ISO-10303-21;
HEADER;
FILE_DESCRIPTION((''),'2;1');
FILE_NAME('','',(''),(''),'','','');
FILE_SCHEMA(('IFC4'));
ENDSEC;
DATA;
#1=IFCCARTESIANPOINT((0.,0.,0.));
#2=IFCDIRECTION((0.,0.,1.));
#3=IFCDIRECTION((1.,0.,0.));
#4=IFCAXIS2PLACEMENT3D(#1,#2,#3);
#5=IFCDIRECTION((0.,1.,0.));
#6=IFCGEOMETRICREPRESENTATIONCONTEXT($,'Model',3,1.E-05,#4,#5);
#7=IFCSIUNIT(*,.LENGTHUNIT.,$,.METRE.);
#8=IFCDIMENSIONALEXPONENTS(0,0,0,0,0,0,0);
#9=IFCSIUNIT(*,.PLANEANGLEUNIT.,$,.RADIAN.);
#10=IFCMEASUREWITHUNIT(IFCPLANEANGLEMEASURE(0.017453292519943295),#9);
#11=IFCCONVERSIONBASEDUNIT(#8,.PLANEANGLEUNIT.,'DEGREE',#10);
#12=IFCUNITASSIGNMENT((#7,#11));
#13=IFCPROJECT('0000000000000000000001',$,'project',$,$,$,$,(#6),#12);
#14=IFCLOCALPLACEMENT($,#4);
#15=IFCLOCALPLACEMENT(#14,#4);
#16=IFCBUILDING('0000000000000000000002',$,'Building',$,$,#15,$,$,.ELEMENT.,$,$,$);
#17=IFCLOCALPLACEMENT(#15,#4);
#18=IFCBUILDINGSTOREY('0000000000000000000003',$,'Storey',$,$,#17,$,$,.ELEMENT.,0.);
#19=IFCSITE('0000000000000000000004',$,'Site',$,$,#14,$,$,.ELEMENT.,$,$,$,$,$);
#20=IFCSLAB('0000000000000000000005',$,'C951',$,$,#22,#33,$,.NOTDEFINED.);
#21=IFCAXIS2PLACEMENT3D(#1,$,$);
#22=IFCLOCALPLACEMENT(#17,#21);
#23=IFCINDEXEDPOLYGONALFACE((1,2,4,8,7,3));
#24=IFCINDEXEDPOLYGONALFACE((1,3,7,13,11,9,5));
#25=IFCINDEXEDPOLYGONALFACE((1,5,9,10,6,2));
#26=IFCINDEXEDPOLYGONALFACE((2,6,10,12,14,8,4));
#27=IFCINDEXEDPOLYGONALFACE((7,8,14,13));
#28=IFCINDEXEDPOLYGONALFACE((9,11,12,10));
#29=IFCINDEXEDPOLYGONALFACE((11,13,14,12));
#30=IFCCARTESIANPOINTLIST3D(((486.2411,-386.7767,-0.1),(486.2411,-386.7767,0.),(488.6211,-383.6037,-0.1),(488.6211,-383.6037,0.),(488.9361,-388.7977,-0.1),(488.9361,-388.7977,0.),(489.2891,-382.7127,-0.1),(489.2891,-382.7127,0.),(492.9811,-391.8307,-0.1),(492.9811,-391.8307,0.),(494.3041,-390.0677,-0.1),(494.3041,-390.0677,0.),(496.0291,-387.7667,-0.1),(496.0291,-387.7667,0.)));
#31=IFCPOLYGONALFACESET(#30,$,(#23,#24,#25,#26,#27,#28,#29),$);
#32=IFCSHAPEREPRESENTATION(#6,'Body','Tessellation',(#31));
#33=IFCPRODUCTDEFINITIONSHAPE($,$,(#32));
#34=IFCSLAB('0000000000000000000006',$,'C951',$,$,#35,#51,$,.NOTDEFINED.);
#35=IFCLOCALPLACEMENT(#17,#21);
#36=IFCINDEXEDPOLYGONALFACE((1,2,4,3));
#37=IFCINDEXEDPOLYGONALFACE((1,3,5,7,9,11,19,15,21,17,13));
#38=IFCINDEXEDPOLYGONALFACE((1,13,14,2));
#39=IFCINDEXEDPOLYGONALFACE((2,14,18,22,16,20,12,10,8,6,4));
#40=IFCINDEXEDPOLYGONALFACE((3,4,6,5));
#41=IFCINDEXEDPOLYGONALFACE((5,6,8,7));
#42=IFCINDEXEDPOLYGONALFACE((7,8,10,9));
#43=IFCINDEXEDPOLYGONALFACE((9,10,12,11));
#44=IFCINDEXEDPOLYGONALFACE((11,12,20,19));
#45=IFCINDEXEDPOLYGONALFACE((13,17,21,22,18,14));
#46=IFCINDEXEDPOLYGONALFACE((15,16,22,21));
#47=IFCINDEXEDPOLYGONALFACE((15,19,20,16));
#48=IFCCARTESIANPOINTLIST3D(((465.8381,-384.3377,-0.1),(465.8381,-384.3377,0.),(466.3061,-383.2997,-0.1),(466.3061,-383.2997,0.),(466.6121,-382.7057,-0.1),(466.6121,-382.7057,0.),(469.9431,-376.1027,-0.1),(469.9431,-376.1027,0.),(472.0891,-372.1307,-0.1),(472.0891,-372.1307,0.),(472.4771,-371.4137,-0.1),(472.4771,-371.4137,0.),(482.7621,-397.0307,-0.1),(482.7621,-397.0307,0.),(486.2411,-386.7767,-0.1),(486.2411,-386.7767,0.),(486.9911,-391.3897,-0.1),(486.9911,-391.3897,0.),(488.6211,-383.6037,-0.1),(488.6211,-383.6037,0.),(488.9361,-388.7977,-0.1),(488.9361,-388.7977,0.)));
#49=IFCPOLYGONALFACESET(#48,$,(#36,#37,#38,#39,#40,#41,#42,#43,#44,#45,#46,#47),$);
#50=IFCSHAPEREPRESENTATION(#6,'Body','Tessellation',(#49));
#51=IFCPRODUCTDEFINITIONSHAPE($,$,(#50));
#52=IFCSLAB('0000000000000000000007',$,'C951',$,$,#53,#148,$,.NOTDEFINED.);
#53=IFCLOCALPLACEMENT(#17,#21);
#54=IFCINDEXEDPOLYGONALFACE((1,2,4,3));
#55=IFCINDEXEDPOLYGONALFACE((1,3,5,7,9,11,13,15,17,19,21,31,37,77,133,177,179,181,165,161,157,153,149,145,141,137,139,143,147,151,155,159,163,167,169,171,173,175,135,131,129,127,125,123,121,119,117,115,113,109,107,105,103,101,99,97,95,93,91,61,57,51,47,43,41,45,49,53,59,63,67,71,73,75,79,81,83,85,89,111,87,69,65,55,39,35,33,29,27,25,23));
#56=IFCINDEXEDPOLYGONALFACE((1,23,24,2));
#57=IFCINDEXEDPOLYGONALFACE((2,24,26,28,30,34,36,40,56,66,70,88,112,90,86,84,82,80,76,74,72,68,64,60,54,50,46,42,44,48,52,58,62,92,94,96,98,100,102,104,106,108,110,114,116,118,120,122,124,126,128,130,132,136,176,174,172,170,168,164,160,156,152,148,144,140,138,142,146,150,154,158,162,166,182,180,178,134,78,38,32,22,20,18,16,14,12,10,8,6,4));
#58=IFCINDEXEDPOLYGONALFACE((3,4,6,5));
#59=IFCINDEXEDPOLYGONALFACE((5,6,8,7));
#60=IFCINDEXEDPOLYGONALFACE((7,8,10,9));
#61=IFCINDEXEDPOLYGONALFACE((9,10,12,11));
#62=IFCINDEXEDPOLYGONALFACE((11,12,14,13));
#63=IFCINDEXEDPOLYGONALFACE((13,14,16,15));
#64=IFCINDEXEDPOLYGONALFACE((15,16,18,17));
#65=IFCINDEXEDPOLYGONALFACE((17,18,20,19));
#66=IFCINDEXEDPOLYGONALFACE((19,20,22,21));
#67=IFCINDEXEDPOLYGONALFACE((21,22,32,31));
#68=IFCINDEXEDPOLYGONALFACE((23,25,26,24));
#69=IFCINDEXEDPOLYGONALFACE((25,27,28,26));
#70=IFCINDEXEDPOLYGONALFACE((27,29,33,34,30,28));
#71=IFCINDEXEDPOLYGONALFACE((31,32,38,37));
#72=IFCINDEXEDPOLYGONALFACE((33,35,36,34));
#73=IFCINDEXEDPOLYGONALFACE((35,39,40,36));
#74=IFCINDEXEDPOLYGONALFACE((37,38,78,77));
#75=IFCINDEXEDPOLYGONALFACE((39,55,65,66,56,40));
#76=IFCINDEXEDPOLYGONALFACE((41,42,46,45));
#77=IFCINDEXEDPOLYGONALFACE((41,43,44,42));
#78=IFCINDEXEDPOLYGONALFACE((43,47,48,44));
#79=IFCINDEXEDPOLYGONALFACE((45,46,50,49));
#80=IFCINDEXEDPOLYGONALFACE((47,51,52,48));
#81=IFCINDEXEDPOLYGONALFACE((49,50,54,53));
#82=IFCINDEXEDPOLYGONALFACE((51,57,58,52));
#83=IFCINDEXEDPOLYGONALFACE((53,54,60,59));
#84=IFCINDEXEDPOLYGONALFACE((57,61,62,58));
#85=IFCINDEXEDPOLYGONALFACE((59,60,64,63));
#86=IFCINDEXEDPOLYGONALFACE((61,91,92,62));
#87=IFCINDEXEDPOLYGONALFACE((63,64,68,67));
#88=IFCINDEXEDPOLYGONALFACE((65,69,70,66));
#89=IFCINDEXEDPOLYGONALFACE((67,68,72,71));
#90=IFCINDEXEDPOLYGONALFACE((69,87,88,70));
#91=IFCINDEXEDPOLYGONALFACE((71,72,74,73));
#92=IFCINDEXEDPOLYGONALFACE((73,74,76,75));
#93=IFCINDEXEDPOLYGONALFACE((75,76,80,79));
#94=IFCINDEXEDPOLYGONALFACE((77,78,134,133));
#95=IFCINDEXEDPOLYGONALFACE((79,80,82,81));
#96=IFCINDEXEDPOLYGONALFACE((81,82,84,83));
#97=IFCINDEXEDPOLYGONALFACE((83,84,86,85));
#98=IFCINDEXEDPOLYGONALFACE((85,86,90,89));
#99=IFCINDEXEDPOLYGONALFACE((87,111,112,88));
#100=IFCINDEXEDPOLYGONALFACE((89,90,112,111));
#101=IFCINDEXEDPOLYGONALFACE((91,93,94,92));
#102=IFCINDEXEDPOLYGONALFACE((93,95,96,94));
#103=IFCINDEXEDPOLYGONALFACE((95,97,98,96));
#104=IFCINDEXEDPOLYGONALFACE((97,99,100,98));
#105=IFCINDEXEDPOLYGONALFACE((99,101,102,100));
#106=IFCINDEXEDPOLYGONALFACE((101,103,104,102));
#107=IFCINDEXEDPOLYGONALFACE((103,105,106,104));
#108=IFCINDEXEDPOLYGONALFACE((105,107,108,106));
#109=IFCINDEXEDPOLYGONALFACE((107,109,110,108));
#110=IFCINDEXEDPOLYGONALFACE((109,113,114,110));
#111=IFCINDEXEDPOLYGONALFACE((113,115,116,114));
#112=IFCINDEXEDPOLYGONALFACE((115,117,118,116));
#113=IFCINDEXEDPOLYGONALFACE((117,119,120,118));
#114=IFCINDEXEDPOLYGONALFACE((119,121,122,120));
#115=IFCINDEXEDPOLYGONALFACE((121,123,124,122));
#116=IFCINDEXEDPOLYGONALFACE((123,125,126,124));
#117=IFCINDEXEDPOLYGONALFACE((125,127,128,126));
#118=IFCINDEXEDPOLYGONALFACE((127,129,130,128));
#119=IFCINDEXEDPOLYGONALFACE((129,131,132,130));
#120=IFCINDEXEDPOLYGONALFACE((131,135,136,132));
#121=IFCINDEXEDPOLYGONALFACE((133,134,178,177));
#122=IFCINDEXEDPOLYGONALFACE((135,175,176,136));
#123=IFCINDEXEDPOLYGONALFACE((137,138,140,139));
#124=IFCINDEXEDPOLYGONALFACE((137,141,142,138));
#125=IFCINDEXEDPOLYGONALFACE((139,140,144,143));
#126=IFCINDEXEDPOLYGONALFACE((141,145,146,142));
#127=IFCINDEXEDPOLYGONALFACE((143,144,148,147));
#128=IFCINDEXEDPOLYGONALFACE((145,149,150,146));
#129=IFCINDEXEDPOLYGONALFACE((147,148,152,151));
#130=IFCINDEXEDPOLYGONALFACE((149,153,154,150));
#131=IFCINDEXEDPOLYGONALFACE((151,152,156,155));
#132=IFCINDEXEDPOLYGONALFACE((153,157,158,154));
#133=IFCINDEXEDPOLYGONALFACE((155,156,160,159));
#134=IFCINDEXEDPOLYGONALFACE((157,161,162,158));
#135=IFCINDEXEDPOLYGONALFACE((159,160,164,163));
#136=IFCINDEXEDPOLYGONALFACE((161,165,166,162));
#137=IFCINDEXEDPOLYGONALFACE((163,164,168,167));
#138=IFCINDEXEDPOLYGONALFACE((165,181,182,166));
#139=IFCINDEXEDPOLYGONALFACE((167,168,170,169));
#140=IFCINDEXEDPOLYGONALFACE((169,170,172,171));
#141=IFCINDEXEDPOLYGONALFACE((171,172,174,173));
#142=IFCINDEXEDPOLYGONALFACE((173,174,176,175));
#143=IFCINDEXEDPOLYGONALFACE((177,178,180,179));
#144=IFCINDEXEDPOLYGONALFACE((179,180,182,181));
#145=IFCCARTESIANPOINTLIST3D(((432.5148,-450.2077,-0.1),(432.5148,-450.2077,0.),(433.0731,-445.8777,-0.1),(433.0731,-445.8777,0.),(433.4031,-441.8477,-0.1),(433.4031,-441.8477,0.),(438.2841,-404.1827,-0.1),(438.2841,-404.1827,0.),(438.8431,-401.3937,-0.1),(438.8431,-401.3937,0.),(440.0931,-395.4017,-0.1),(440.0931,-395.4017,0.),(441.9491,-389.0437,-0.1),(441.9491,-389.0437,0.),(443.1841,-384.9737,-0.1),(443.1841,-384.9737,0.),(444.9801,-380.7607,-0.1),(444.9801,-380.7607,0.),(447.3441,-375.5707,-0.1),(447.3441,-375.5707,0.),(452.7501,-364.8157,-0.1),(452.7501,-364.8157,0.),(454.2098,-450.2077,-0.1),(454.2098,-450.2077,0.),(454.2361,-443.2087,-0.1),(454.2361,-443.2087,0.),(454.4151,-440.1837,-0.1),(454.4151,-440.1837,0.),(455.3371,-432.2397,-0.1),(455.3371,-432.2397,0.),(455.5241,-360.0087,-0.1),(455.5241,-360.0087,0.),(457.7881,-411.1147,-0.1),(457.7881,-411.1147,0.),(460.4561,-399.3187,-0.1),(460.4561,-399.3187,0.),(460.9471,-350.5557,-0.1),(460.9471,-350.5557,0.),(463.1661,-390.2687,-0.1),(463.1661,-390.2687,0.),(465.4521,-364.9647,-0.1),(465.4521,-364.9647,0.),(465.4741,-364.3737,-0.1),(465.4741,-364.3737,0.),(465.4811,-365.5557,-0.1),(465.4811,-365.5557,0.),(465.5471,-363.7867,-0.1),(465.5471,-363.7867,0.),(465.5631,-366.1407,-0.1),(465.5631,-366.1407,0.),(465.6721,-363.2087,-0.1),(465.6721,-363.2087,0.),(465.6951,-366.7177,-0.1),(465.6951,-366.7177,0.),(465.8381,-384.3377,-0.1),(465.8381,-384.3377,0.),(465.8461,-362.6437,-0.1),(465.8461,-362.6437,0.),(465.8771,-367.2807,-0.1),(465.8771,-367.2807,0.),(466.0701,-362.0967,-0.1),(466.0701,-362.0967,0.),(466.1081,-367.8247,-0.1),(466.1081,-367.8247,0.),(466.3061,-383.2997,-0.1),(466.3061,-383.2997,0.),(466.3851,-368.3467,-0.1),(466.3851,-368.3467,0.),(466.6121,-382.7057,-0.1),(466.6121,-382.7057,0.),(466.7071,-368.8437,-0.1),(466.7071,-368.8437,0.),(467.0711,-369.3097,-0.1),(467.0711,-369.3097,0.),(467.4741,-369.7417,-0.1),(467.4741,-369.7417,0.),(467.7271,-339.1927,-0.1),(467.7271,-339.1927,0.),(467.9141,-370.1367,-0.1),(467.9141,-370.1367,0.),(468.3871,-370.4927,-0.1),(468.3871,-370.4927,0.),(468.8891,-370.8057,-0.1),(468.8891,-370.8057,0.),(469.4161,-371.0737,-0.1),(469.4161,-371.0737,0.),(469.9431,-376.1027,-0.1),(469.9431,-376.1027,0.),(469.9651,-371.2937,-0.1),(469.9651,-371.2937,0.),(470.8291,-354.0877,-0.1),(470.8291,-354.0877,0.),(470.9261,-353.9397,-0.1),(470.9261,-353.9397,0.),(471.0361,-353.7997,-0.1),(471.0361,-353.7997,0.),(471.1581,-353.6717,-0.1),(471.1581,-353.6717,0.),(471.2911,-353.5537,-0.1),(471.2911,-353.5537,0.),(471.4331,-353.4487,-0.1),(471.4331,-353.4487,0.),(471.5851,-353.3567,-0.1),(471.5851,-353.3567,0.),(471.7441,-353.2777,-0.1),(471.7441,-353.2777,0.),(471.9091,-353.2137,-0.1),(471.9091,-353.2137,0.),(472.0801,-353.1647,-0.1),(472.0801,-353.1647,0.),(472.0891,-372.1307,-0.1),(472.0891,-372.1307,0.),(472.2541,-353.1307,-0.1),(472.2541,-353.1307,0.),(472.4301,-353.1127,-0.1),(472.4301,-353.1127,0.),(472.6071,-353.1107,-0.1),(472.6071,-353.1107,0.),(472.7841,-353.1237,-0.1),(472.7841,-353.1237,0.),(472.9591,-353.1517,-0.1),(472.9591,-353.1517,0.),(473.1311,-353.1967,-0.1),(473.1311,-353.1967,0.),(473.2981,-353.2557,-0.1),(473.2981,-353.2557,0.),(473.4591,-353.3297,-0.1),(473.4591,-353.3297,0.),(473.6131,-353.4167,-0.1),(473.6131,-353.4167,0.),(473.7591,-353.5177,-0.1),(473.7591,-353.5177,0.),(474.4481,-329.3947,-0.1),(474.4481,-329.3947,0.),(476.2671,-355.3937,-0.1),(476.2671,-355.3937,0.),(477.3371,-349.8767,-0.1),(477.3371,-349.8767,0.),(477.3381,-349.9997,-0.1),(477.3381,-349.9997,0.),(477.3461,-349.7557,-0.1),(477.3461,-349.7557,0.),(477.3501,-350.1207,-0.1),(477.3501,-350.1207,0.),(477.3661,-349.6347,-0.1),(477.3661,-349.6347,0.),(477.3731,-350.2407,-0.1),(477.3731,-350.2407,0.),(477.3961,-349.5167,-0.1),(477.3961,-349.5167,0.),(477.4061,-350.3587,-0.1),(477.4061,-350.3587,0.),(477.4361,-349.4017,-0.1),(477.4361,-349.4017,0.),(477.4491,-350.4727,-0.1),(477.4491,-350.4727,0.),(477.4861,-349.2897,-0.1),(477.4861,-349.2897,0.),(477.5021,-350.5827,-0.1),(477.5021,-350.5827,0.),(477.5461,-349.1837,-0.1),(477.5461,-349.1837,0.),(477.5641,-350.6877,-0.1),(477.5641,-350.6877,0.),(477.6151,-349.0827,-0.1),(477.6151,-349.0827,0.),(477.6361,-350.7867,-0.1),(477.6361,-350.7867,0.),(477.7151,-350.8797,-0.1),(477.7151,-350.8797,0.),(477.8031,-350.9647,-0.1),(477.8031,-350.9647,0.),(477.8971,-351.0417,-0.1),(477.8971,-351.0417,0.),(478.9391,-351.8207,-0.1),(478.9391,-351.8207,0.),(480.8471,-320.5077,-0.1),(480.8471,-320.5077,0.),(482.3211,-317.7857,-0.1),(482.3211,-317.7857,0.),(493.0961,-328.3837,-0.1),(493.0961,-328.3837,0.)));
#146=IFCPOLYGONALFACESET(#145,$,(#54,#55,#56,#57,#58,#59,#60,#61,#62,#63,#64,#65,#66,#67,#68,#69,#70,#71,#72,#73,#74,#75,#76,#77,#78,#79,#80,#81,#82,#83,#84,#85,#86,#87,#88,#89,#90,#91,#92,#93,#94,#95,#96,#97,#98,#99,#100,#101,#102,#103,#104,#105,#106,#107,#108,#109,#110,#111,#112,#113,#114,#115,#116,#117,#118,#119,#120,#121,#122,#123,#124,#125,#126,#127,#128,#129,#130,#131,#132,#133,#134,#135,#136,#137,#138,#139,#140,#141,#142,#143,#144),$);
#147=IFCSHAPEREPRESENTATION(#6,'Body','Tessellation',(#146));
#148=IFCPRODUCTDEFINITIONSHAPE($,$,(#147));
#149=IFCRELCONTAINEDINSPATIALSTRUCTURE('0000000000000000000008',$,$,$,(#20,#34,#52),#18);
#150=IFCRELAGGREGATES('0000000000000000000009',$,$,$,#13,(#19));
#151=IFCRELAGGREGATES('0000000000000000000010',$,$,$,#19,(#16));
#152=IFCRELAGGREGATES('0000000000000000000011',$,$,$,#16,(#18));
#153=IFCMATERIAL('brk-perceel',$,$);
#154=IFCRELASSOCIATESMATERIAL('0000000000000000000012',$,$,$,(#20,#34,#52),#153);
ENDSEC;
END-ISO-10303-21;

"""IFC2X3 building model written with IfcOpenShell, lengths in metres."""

from ifc_helpers import new_model, entity, si_unit, converted_unit, direction, frame, origin_with_axes, place, context, project, spatial, polyline, outline, extrude, material, element, save


model = new_model("IFC2X3")

# Units and contexts
model_context = context("Model", 3, precision=1e-05, world=origin_with_axes(), true_north=direction((0.0, 1.0, 0.0)))
ifc_project = project(units=[si_unit("LENGTHUNIT", "METRE"), converted_unit("PLANEANGLEUNIT", "DEGREE", entity("IfcPlaneAngleMeasure", 0.017453292519943295), si_unit("PLANEANGLEUNIT", "RADIAN"), dimensions=[0, 0, 0, 0, 0, 0, 0])], contexts=[model_context])

# Site, building, storey
site_placement = place(None, origin_with_axes())
site = spatial("IfcSite", under=ifc_project, at=site_placement, Name="Site", CompositionType="ELEMENT")
building_placement = place(site_placement, origin_with_axes())
building = spatial("IfcBuilding", under=site, at=building_placement, Name="Building", CompositionType="ELEMENT")
storey_placement = place(building_placement, origin_with_axes())
storey = spatial("IfcBuildingStorey", under=building, at=storey_placement, Name="Storey", CompositionType="ELEMENT", Elevation=0.0)

# Slabs
ifc_material = material(Name="brk-perceel")
slab_1_placement = place(storey_placement, frame((0.0, 0.0, -0.1), z_axis=(0.0, 0.0, 1.0), x_axis=(1.0, 0.0, 0.0)))
element("IfcSlab", 1, at=slab_1_placement, inside=storey, material=ifc_material, Name="C951", PredefinedType="NOTDEFINED", context=model_context, shape_type="SweptSolid", body=[
    extrude(outline(polyline([(489.2891, -382.7127), (496.0291, -387.7667), (494.3041, -390.0677), (492.9811, -391.8307), (488.9361, -388.7977), (486.2411, -386.7767), (488.6211, -383.6037), (489.2891, -382.7127)])), origin_with_axes(), (0.0, 0.0, 1.0), 0.1),
])
slab_2_placement = place(storey_placement, frame((0.0, 0.0, -0.1), z_axis=(0.0, 0.0, 1.0), x_axis=(1.0, 0.0, 0.0)))
element("IfcSlab", 2, at=slab_2_placement, inside=storey, material=ifc_material, Name="C951", PredefinedType="NOTDEFINED", context=model_context, shape_type="SweptSolid", body=[
    extrude(outline(polyline([(466.6121, -382.7057), (469.9431, -376.1027), (472.0891, -372.1307), (472.4771, -371.4137), (488.6211, -383.6037), (486.2411, -386.7767), (488.9361, -388.7977), (486.9911, -391.3897), (482.7621, -397.0307), (465.8381, -384.3377), (466.3061, -383.2997), (466.6121, -382.7057)])), origin_with_axes(), (0.0, 0.0, 1.0), 0.1),
])
slab_3_placement = place(storey_placement, frame((0.0, 0.0, -0.1), z_axis=(0.0, 0.0, 1.0), x_axis=(1.0, 0.0, 0.0)))
element("IfcSlab", 3, at=slab_3_placement, inside=storey, material=ifc_material, Name="C951", PredefinedType="NOTDEFINED", context=model_context, shape_type="SweptSolid", body=[
    extrude(outline(polyline([(433.0731, -445.8777), (433.4031, -441.8477), (438.2841, -404.1827), (438.8431, -401.3937), (440.0931, -395.4017), (441.9491, -389.0437), (443.1841, -384.9737), (444.9801, -380.7607), (447.3441, -375.5707), (452.7501, -364.8157), (455.5241, -360.0087), (460.9471, -350.5557), (467.7271, -339.1927), (474.4481, -329.3947), (480.8471, -320.5077), (482.3211, -317.7857), (493.0961, -328.3837), (477.6151, -349.0827), (477.5461, -349.1837), (477.4861, -349.2897), (477.4361, -349.4017), (477.3961, -349.5167), (477.3661, -349.6347), (477.3461, -349.7557), (477.3371, -349.8767), (477.3381, -349.9997), (477.3501, -350.1207), (477.3731, -350.2407), (477.4061, -350.3587), (477.4491, -350.4727), (477.5021, -350.5827), (477.5641, -350.6877), (477.6361, -350.7867), (477.7151, -350.8797), (477.8031, -350.9647), (477.8971, -351.0417), (478.9391, -351.8207), (476.2671, -355.3937), (473.7591, -353.5177), (473.6131, -353.4167), (473.4591, -353.3297), (473.2981, -353.2557), (473.1311, -353.1967), (472.9591, -353.1517), (472.7841, -353.1237), (472.6071, -353.1107), (472.4301, -353.1127), (472.2541, -353.1307), (472.0801, -353.1647), (471.9091, -353.2137), (471.7441, -353.2777), (471.5851, -353.3567), (471.4331, -353.4487), (471.2911, -353.5537), (471.1581, -353.6717), (471.0361, -353.7997), (470.9261, -353.9397), (470.8291, -354.0877), (466.0701, -362.0967), (465.8461, -362.6437), (465.6721, -363.2087), (465.5471, -363.7867), (465.4741, -364.3737), (465.4521, -364.9647), (465.4811, -365.5557), (465.5631, -366.1407), (465.6951, -366.7177), (465.8771, -367.2807), (466.1081, -367.8247), (466.3851, -368.3467), (466.7071, -368.8437), (467.0711, -369.3097), (467.4741, -369.7417), (467.9141, -370.1367), (468.3871, -370.4927), (468.8891, -370.8057), (469.4161, -371.0737), (469.9651, -371.2937), (472.0891, -372.1307), (469.9431, -376.1027), (466.6121, -382.7057), (466.3061, -383.2997), (465.8381, -384.3377), (463.1661, -390.2687), (460.4561, -399.3187), (457.7881, -411.1147), (455.3371, -432.2397), (454.4151, -440.1837), (454.2361, -443.2087), (454.2098, -450.2077), (432.5148, -450.2077), (433.0731, -445.8777)])), origin_with_axes(), (0.0, 0.0, 1.0), 0.1),
])

save(model, "model.ifc")
